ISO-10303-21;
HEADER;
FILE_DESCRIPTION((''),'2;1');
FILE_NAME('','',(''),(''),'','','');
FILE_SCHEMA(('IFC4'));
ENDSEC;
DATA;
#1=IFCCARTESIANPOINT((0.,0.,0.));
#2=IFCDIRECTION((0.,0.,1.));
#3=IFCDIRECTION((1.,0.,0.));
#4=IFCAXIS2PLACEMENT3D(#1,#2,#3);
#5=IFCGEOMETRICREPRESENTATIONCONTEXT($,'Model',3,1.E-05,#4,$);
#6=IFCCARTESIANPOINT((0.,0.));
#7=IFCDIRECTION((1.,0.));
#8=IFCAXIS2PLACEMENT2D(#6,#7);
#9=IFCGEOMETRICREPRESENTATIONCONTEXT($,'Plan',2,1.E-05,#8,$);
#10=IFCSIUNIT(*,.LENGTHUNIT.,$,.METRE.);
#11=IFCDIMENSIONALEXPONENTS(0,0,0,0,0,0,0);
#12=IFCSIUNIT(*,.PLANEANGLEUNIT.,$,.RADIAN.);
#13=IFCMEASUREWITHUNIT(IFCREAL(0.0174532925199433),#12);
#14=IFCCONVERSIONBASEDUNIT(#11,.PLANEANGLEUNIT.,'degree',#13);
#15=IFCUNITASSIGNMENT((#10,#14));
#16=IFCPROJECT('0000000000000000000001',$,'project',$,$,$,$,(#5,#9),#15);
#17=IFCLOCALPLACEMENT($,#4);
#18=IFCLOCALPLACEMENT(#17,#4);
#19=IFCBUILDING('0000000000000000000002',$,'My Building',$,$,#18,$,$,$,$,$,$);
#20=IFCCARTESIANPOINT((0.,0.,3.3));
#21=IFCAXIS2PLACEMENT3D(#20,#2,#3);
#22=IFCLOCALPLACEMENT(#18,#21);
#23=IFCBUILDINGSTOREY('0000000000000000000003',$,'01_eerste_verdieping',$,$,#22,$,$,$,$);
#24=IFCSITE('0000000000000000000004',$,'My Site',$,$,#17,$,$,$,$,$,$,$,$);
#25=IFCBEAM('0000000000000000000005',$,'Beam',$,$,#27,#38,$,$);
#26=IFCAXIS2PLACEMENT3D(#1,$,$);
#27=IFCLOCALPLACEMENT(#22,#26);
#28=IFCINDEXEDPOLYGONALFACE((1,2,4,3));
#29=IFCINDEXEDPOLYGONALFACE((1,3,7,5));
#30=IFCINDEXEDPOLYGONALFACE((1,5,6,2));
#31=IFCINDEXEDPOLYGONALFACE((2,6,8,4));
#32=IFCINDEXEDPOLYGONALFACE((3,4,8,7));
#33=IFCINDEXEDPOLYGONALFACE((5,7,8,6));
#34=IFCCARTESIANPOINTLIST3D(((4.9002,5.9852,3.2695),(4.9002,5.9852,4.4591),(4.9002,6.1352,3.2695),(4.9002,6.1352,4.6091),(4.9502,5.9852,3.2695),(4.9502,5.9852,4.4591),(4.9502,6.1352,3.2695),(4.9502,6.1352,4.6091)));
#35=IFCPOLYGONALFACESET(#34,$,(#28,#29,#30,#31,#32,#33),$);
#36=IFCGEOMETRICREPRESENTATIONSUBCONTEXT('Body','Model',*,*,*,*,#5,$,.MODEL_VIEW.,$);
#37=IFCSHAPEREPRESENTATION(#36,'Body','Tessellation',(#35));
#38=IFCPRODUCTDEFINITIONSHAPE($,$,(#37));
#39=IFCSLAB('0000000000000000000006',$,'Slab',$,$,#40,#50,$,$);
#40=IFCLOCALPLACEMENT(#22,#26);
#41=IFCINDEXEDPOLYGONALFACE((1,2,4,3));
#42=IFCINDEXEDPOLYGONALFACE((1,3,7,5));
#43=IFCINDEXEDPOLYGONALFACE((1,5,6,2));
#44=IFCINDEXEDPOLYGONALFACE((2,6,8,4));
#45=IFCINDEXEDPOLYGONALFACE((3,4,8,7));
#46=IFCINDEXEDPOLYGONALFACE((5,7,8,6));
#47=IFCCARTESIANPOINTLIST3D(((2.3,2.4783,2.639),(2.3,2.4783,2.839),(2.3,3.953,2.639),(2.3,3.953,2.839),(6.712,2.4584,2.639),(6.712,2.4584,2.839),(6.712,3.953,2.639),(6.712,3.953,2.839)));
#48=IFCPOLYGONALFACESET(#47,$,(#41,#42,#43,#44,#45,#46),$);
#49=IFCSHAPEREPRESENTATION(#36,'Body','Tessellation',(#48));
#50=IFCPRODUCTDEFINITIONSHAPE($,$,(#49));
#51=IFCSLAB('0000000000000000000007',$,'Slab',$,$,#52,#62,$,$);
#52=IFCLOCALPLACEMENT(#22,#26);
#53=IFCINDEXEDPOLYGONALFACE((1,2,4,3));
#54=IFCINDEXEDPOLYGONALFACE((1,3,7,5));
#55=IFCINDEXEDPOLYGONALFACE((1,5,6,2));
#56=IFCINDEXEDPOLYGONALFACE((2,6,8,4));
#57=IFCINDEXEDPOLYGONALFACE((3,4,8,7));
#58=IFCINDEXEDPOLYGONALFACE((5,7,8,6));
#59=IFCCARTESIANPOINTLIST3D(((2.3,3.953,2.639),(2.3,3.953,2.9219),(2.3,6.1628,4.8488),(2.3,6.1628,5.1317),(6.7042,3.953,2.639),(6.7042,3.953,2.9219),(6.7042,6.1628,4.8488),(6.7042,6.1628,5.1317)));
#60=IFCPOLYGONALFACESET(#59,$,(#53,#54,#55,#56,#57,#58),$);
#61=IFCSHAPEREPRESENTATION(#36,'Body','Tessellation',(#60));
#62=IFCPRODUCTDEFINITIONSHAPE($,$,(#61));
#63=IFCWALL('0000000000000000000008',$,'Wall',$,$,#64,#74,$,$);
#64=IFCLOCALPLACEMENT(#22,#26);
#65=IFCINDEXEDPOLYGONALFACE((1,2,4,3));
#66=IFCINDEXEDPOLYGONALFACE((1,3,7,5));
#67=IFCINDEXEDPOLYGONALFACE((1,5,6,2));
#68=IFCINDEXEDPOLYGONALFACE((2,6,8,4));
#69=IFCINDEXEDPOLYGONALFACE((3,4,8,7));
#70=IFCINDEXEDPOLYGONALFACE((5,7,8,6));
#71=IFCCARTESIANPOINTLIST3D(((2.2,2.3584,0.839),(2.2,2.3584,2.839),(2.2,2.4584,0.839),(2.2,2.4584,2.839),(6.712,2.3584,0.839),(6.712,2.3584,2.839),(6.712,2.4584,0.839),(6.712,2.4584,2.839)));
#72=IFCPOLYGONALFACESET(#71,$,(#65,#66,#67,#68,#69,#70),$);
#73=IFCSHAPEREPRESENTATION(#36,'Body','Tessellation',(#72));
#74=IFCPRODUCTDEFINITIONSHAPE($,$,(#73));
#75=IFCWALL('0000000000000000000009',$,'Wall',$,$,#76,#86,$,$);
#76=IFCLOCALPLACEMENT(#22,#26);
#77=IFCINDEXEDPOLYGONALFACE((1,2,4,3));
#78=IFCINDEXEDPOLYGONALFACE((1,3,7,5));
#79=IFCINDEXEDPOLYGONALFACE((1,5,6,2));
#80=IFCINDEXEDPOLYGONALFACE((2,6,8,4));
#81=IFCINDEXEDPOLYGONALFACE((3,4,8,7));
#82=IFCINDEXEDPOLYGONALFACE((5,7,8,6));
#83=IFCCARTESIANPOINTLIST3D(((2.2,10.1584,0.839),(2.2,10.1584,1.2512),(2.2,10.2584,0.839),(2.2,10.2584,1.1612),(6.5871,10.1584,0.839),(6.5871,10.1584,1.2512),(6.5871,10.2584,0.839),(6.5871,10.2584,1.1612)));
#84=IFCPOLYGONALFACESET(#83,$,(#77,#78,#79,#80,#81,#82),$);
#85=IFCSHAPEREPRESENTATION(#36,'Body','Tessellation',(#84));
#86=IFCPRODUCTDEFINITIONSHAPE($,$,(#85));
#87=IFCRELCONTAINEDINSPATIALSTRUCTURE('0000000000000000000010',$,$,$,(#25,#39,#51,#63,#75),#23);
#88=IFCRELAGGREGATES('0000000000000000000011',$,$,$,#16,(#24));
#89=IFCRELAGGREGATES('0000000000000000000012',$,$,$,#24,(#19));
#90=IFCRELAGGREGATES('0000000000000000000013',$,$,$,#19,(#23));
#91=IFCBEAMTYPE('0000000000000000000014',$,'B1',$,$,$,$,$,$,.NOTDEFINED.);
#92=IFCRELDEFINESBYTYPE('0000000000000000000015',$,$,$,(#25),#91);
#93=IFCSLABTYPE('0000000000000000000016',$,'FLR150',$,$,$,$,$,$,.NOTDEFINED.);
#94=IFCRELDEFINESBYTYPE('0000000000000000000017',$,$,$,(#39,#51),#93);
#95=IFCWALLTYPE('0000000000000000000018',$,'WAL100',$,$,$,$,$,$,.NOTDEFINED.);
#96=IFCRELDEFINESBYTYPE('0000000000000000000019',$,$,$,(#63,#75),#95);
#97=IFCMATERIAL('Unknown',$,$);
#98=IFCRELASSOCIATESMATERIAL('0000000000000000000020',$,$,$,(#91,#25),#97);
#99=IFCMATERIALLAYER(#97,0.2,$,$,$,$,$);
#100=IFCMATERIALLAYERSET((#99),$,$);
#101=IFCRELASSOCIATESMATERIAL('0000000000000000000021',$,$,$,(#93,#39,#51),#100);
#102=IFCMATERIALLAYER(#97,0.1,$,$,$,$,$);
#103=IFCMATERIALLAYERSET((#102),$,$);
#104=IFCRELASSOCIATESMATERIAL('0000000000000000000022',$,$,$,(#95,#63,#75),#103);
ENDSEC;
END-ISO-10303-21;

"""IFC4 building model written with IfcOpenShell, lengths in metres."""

from ifc_helpers import new_model, entity, si_unit, converted_unit, frame, origin_with_axes, origin_2d_with_axis, place, context, subcontext, project, spatial, line, indexed_curve, rectangle, outline, extrude, clip, halfspace, material, layer, layer_set, layer_usage, material_profile, profile_set, profile_usage, type_object, element, save


model = new_model("IFC4")

# Units and contexts
model_context = context("Model", 3, precision=1e-05, world=origin_with_axes())
plan_context = context("Plan", 2, precision=1e-05, world=origin_2d_with_axis())
body_context_1 = subcontext(model_context, "Body", "Model", "MODEL_VIEW")
ifc_project = project(units=[si_unit("LENGTHUNIT", "METRE"), converted_unit("PLANEANGLEUNIT", "degree", entity("IfcReal", 0.0174532925199433), si_unit("PLANEANGLEUNIT", "RADIAN"), dimensions=[0, 0, 0, 0, 0, 0, 0])], contexts=[model_context, plan_context])

# Site, building, storey
site_placement = place(None, origin_with_axes())
site = spatial("IfcSite", under=ifc_project, at=site_placement, Name="My Site")
building_placement = place(site_placement, origin_with_axes())
building = spatial("IfcBuilding", under=site, at=building_placement, Name="My Building")
storey_placement = place(building_placement, frame((0.0, 0.0, 3.3), z_axis=(0.0, 0.0, 1.0), x_axis=(1.0, 0.0, 0.0)))
storey = spatial("IfcBuildingStorey", under=building, at=storey_placement, Name="01_eerste_verdieping")

# Beam
ifc_material_1 = material(Name="Unknown")
ifc_material_profile_1 = material_profile(ifc_material_1, rectangle(XDim=0.05, YDim=0.15))
ifc_profile_set_1 = profile_set([ifc_material_profile_1])
beam_type = type_object("IfcBeamType", Name="B1", PredefinedType="NOTDEFINED", material=ifc_profile_set_1)
ifc_profile_usage_1 = profile_usage(ifc_profile_set_1, cardinal=5)
beam_1_placement = place(storey_placement, frame((4.9252, 6.0602, 3.2695), z_axis=(0.0, 0.0, 1.0), x_axis=(-1.0, 0.0, 0.0)))
element("IfcBeam", 1, at=beam_1_placement, inside=storey, type_object=beam_type, material=ifc_profile_usage_1, Name="Beam", context=body_context_1, shape_type="Clipping", body=[
    clip(extrude(rectangle(XDim=0.05, YDim=0.15), origin_with_axes(), (0.0, 0.0, 1.0), 1.4146), halfspace(frame((0.0, 2.0011, -0.7365), z_axis=(0.0, 0.707107, 0.707107), x_axis=(1.0, 0.0, 0.0)), False)),
])

# Slabs
ifc_layer_1 = layer(ifc_material_1, 0.2)
ifc_layer_set_1 = layer_set([ifc_layer_1])
ifc_layer_usage_1 = layer_usage(ifc_layer_set_1, "AXIS3", "POSITIVE", 0.0)
slab_type_1 = type_object("IfcSlabType", Name="FLR150", PredefinedType="NOTDEFINED", material=ifc_layer_set_1)
slab_1_placement = place(storey_placement, frame((2.3, 2.4783, 2.639), z_axis=(0.0, 0.0, 1.0), x_axis=(1.0, 0.0, 0.0)))
element("IfcSlab", 2, at=slab_1_placement, inside=storey, type_object=slab_type_1, material=ifc_layer_usage_1, Name="Slab", context=body_context_1, shape_type="SweptSolid", body=[
    extrude(outline(indexed_curve([(0.0, 1.4747), (0.0, 0.0), (4.412, -0.0199), (4.412, 1.4747)], segments=[line(4, 1), line(1, 2), line(2, 3), line(3, 4)], self_intersect=False)), None, (0.0, 0.0, 1.0), 0.2),
])
ifc_layer_usage_2 = layer_usage(ifc_layer_set_1, "AXIS3", "POSITIVE", 0.0)
slab_2_placement = place(storey_placement, frame((2.3, 3.953, 2.639), z_axis=(0.0, -0.707107, 0.707107), x_axis=(1.0, 0.0, 0.0)))
element("IfcSlab", 3, at=slab_2_placement, inside=storey, type_object=slab_type_1, material=ifc_layer_usage_2, Name="Slab", context=body_context_1, shape_type="SweptSolid", body=[
    extrude(outline(indexed_curve([(4.4042, 0.0), (0.0, 0.0), (0.0, 3.1252), (4.4042, 3.1252)], segments=[line(4, 1), line(1, 2), line(2, 3), line(3, 4)], self_intersect=False)), None, (0.0, 0.707107, 0.707107), 0.2828),
])

# Walls
ifc_layer_2 = layer(ifc_material_1, 0.1)
ifc_layer_set_2 = layer_set([ifc_layer_2])
ifc_layer_usage_3 = layer_usage(ifc_layer_set_2, "AXIS2", "POSITIVE", 0.0)
wall_type_1 = type_object("IfcWallType", Name="WAL100", PredefinedType="NOTDEFINED", material=ifc_layer_set_2)
wall_1_placement = place(storey_placement, frame((2.2, 2.3584, 0.839), z_axis=(0.0, 0.0, 1.0), x_axis=(1.0, 0.0, 0.0)))
element("IfcWall", 4, at=wall_1_placement, inside=storey, type_object=wall_type_1, material=ifc_layer_usage_3, Name="Wall", context=body_context_1, shape_type="SweptSolid", body=[
    extrude(outline(indexed_curve([(0.0, 0.0), (0.0, 0.1), (4.512, 0.1), (4.512, 0.0), (0.0, 0.0)], self_intersect=False)), origin_with_axes(), (0.0, 0.0, 1.0), 2.0),
])
ifc_layer_usage_4 = layer_usage(ifc_layer_set_2, "AXIS2", "POSITIVE", 0.0)
wall_2_placement = place(storey_placement, frame((6.5871, 10.2584, 0.839), z_axis=(0.0, 0.0, 1.0), x_axis=(-1.0, 0.0, 0.0)))
element("IfcWall", 5, at=wall_2_placement, inside=storey, type_object=wall_type_1, material=ifc_layer_usage_4, Name="Wall", context=body_context_1, shape_type="Clipping", body=[
    clip(extrude(outline(indexed_curve([(0.0, 0.0), (0.0, 0.1), (4.3871, 0.1), (4.3871, 0.0), (0.0, 0.0)], self_intersect=False)), origin_with_axes(), (0.0, 0.0, 1.0), 4.5512), halfspace(frame((0.0, 0.1, 0.4122), z_axis=(0.0, -0.669131, 0.743145), x_axis=(-1.0, 0.0, 0.0)), False)),
])

save(model, "model.ifc")
